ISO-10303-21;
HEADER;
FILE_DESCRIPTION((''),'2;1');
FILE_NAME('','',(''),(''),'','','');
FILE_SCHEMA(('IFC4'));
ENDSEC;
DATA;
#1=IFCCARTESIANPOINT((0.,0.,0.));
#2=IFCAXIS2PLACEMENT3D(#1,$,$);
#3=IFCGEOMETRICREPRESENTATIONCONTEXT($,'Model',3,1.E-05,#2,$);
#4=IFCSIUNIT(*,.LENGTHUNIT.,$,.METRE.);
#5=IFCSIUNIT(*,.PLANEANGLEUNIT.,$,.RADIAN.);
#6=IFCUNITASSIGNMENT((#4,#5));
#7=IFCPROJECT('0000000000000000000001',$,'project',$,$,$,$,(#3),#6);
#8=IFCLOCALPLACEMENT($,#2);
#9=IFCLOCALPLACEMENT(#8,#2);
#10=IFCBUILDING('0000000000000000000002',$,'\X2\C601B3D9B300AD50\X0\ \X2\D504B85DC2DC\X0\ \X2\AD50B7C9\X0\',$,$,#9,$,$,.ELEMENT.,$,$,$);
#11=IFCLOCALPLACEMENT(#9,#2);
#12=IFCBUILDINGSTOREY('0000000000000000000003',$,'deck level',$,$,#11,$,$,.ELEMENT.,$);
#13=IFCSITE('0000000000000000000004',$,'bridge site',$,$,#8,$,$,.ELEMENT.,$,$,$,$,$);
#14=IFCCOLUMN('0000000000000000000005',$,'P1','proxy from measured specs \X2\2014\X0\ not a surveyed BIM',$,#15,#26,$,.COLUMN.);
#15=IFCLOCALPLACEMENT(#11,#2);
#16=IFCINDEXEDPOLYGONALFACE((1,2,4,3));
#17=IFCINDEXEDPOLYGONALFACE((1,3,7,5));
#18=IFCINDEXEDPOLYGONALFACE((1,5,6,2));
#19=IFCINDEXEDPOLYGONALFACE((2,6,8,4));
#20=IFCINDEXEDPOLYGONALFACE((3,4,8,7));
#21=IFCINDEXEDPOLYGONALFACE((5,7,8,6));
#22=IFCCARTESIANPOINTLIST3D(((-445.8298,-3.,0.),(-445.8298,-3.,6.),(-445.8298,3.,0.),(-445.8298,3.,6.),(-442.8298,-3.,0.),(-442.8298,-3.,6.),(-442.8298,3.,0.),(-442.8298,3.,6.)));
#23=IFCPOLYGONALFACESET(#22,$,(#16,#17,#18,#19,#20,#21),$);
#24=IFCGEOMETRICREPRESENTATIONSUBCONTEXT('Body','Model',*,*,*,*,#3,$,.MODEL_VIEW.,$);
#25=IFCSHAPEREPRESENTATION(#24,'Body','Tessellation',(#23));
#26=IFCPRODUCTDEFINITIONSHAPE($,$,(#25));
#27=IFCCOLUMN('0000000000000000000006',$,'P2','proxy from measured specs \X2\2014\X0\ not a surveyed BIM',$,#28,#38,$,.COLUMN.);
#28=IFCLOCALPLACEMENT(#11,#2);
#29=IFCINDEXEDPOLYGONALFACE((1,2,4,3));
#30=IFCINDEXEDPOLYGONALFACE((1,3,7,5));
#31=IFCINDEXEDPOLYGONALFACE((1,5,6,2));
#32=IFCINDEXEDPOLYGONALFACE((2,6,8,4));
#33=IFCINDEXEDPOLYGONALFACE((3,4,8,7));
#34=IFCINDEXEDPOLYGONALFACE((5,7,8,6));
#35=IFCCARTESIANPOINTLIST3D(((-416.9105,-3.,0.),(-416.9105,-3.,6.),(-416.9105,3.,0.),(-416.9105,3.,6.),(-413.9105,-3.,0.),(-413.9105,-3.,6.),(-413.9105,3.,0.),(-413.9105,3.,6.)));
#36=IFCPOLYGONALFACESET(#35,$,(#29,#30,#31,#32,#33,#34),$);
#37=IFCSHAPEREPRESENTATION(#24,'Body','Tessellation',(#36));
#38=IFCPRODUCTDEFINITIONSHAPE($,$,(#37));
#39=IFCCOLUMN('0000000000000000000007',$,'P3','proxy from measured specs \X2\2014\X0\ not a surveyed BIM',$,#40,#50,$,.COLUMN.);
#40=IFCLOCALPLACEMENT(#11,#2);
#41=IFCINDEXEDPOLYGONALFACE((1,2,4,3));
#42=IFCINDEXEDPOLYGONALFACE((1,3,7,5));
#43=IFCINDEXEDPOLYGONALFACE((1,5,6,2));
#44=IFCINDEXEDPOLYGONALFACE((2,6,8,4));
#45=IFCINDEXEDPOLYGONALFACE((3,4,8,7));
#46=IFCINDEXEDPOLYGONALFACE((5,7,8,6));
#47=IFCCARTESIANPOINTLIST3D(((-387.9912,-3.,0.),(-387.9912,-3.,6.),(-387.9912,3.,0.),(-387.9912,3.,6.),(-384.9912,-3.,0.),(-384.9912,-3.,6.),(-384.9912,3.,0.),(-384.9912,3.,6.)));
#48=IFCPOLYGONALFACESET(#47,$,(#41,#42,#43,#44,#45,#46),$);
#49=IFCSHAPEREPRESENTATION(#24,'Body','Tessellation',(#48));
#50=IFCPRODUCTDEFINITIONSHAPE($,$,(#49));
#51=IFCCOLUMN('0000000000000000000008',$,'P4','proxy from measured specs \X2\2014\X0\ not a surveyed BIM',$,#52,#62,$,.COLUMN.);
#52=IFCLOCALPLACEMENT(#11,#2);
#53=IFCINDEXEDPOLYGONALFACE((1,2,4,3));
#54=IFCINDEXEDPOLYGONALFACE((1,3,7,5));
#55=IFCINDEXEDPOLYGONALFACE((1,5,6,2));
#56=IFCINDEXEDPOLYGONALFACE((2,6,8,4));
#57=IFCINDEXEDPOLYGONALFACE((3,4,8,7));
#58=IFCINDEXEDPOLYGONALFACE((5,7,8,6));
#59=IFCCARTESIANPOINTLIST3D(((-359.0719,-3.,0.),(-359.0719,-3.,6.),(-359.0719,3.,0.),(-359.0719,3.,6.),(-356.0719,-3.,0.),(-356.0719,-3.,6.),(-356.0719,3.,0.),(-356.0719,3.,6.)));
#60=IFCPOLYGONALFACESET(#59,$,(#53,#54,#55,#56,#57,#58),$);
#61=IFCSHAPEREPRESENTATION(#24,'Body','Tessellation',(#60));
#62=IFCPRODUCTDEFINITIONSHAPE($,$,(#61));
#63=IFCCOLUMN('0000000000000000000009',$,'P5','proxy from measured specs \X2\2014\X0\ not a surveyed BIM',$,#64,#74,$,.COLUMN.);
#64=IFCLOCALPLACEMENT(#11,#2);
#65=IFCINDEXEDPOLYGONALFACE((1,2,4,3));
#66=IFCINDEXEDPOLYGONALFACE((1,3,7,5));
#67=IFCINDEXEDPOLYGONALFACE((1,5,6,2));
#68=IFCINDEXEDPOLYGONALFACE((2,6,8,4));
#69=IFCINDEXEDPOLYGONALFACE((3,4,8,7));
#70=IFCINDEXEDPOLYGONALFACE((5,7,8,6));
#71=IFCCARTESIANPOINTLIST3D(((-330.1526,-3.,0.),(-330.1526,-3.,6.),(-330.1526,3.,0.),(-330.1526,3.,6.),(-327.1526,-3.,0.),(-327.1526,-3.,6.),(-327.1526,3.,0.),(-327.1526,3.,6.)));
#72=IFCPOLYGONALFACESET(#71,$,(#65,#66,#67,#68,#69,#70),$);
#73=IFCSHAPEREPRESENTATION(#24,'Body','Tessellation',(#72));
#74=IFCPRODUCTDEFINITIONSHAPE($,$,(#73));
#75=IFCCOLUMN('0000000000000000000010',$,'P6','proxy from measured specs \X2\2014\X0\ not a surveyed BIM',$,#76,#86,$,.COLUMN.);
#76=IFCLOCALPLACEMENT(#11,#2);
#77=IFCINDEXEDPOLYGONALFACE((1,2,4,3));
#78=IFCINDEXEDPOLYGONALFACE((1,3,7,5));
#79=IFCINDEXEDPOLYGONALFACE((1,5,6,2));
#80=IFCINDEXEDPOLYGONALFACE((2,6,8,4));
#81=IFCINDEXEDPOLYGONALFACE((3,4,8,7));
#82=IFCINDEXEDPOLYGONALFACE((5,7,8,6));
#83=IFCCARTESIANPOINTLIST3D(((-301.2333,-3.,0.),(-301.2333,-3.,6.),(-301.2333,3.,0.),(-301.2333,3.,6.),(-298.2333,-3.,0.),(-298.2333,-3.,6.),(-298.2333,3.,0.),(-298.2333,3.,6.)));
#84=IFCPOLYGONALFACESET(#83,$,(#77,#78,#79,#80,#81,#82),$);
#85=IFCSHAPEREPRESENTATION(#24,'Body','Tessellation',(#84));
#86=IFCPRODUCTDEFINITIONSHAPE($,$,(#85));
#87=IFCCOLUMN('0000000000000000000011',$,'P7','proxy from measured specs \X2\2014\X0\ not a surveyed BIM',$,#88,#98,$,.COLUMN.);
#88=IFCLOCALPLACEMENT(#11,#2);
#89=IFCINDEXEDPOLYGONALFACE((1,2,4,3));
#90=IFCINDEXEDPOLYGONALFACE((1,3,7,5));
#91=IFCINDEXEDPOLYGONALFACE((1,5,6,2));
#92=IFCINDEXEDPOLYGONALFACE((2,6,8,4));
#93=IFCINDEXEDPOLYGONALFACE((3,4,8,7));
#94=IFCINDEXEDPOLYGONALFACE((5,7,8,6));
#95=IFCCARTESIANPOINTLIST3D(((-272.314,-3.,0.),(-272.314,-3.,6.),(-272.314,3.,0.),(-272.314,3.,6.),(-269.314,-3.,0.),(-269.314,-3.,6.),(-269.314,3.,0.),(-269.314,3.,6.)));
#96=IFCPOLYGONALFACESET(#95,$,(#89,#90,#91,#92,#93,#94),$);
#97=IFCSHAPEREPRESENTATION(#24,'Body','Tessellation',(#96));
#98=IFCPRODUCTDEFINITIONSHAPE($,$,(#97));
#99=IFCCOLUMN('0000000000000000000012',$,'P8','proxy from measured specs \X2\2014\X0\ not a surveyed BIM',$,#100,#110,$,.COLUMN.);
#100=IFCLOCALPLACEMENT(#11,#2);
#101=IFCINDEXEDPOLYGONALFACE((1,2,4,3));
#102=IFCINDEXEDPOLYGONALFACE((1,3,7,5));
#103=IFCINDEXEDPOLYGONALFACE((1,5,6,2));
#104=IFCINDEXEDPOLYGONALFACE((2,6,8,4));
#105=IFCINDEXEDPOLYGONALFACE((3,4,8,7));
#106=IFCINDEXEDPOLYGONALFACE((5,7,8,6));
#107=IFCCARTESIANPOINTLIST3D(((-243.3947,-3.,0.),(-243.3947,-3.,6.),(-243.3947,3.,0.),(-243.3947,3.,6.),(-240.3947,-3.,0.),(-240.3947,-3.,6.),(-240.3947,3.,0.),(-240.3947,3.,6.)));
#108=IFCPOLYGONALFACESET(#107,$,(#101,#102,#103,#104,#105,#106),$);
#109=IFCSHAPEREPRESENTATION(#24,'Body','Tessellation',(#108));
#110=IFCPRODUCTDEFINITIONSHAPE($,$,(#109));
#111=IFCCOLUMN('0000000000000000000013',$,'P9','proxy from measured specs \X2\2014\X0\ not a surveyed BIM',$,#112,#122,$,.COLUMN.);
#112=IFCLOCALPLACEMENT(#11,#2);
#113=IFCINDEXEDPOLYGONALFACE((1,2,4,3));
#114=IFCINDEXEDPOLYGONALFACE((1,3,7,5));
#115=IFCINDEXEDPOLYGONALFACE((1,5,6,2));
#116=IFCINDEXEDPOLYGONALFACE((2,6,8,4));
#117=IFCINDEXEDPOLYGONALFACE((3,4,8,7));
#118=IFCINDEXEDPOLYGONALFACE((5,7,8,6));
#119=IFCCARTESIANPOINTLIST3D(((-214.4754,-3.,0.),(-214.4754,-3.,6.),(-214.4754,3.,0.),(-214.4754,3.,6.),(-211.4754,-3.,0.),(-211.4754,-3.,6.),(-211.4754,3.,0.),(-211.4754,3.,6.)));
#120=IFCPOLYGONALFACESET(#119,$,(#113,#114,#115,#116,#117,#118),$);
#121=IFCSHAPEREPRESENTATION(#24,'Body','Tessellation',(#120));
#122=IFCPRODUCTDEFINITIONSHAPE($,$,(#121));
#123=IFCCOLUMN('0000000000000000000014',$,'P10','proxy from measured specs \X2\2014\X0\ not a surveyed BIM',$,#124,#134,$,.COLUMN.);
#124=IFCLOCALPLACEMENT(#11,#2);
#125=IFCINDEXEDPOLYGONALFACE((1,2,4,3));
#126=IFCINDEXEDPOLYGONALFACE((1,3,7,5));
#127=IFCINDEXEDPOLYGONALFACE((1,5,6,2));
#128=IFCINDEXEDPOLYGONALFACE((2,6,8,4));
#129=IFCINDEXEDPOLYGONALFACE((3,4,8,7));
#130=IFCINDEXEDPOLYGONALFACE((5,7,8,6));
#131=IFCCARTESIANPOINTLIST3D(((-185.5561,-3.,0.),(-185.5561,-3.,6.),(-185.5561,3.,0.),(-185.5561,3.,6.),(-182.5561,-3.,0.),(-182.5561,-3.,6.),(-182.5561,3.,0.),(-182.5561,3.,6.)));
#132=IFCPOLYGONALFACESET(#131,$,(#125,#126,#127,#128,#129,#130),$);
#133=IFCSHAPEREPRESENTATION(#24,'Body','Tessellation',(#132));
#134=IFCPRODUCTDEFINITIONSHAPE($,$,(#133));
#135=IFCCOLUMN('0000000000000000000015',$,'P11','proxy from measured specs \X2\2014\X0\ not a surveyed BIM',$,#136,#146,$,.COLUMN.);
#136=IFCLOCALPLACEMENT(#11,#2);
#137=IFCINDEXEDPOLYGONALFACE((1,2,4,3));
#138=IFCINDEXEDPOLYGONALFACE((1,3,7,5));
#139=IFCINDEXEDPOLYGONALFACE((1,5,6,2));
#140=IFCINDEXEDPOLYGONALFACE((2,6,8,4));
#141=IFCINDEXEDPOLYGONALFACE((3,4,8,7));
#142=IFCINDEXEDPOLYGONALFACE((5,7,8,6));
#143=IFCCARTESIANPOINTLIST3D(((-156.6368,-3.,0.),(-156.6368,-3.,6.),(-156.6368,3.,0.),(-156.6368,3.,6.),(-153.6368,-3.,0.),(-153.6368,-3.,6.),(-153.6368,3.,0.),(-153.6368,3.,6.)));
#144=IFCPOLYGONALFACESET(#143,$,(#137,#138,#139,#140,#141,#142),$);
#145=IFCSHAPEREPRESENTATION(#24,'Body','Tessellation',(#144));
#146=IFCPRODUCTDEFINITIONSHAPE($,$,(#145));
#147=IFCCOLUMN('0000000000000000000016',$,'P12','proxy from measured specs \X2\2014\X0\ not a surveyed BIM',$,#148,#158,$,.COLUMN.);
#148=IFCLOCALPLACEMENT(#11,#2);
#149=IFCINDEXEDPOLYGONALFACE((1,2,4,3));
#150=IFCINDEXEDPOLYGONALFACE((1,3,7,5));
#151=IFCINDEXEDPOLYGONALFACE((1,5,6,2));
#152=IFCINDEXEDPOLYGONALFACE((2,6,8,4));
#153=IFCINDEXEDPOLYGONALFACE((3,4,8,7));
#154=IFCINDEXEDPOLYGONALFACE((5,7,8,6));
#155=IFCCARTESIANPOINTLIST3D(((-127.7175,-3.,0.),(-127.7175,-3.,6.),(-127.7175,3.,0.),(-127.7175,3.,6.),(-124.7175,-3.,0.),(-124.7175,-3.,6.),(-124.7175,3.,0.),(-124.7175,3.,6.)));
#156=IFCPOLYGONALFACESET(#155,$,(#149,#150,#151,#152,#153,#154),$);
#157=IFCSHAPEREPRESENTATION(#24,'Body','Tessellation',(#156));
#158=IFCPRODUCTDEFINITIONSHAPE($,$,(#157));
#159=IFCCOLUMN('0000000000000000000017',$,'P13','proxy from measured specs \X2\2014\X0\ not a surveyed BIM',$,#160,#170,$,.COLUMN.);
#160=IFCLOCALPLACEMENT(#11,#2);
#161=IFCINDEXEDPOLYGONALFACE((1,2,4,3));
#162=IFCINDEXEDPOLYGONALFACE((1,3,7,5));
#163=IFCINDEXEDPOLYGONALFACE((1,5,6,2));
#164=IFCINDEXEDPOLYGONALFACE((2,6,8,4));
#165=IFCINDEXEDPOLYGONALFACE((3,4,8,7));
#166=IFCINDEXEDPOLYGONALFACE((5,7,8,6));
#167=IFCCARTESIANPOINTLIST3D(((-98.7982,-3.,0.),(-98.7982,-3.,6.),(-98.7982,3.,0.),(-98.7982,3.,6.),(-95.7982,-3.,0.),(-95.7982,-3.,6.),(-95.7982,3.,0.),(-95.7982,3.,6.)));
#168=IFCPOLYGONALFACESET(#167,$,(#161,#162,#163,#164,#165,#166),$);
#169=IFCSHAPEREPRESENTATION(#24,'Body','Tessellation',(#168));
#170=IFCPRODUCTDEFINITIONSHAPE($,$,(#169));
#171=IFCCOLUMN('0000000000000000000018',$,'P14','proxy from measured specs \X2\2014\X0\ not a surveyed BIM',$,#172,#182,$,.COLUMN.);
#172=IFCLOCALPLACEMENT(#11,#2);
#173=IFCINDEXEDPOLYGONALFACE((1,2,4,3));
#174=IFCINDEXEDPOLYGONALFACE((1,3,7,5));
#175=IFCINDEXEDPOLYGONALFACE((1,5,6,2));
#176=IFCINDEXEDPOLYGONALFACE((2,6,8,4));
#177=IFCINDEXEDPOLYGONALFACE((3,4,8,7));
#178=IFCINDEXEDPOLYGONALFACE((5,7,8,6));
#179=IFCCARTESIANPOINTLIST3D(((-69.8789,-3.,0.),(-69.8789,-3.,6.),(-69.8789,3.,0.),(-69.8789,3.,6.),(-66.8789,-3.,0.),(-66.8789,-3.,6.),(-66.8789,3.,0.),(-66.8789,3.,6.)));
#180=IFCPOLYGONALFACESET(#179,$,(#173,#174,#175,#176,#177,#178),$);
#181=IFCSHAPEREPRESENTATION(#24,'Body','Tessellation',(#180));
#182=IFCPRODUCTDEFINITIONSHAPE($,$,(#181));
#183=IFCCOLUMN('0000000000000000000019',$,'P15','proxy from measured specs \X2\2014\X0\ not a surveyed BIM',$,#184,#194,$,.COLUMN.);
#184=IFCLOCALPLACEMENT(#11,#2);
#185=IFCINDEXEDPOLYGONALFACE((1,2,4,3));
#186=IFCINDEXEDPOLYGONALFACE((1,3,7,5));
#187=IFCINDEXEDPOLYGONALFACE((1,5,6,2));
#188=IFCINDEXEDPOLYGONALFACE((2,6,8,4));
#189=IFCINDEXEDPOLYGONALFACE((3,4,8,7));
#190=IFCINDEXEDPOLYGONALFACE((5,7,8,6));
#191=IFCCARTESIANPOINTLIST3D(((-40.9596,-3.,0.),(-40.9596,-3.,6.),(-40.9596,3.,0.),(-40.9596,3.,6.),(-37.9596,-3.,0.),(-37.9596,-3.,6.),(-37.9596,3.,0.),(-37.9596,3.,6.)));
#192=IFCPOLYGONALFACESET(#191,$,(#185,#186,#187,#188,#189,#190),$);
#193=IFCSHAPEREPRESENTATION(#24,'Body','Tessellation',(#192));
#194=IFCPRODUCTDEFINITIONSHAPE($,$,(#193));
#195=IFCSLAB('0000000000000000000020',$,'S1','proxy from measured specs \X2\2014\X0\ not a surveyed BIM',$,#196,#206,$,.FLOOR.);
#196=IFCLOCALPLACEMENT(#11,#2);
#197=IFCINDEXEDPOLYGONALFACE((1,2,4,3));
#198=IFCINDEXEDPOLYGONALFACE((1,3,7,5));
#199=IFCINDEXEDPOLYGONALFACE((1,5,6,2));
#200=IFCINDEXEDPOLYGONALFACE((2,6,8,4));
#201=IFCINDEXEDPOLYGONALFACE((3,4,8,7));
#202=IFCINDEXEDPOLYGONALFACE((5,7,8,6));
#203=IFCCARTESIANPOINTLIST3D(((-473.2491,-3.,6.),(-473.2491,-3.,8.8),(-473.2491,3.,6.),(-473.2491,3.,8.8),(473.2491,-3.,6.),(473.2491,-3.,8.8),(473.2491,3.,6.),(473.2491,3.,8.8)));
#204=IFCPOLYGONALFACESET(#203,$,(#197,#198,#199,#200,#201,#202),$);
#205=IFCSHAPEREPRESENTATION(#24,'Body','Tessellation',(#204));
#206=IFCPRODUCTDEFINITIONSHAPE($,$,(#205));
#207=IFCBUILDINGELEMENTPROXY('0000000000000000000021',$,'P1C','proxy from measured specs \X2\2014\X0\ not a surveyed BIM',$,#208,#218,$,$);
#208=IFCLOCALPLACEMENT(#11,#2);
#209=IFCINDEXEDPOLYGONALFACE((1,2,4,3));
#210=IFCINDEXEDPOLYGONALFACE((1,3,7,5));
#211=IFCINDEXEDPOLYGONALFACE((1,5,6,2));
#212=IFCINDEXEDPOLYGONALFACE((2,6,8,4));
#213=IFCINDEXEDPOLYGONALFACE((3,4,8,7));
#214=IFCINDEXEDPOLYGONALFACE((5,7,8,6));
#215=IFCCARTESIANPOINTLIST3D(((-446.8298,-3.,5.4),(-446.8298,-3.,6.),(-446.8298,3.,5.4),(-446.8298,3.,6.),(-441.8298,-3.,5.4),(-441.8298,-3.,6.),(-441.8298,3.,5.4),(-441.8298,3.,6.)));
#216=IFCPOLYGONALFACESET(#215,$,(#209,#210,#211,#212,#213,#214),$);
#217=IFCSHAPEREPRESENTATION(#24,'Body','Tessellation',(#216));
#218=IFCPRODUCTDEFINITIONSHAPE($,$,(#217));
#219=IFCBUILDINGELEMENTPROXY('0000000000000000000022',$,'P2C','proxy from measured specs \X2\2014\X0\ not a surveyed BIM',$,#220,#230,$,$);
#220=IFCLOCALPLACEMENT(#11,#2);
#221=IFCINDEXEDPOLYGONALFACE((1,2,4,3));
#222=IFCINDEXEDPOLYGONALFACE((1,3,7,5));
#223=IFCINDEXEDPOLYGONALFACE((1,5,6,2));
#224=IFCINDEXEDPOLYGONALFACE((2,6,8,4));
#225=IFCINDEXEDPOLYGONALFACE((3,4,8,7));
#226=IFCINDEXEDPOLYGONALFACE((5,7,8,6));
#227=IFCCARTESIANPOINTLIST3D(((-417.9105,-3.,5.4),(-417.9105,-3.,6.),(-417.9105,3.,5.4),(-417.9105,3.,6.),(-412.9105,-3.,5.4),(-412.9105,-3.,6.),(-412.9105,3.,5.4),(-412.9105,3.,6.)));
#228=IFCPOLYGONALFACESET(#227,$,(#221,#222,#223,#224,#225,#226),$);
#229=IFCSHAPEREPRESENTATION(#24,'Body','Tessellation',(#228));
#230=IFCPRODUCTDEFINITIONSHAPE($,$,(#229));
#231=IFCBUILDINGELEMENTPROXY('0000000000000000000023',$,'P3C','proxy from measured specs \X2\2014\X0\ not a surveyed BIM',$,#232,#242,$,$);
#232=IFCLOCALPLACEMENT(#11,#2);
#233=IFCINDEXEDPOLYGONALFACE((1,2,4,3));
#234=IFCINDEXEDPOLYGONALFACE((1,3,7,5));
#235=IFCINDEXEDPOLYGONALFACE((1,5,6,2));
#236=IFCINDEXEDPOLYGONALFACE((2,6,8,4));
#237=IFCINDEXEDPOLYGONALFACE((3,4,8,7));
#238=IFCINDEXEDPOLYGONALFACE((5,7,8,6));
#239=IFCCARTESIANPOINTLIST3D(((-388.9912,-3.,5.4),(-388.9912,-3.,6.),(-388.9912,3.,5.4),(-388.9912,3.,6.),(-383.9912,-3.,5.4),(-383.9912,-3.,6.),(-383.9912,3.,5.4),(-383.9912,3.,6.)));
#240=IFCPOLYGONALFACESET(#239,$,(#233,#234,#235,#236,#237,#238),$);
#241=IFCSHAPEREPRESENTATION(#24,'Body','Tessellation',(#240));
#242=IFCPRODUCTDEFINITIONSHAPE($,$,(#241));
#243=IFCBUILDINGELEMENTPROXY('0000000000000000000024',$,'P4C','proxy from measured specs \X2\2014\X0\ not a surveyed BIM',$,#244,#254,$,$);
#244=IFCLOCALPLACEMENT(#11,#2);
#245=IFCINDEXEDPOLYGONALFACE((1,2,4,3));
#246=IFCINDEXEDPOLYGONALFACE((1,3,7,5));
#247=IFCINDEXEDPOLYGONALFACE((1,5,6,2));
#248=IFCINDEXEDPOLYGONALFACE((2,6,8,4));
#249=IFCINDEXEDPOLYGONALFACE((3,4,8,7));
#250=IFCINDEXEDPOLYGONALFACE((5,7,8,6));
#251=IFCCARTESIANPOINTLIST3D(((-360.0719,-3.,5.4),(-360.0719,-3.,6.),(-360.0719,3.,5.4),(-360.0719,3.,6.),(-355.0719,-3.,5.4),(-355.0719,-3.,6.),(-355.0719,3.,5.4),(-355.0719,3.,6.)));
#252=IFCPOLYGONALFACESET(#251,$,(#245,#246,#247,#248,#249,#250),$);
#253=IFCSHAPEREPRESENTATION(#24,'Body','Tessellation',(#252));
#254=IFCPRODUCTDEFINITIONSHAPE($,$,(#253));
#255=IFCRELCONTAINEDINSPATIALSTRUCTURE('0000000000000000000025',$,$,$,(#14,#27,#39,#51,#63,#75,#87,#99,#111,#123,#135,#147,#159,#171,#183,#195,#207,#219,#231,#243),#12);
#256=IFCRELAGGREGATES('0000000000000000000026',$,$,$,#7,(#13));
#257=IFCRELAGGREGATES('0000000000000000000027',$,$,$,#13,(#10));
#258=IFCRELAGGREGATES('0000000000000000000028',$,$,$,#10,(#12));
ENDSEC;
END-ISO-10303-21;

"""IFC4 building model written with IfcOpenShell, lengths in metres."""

from ifc_helpers import new_model, si_unit, frame, origin, origin_2d, place, context, subcontext, project, spatial, rectangle, extrude, element, save


model = new_model("IFC4")

# Units and contexts
model_context = context("Model", 3, precision=1e-05, world=origin())
body_context = subcontext(model_context, "Body", "Model", "MODEL_VIEW")
ifc_project = project(units=[si_unit("LENGTHUNIT", "METRE"), si_unit("PLANEANGLEUNIT", "RADIAN")], contexts=[model_context])

# Site, building, storey
site_placement = place(None, origin())
site = spatial("IfcSite", under=ifc_project, at=site_placement, Name="bridge site", CompositionType="ELEMENT")
building_placement = place(site_placement, origin())
building = spatial("IfcBuilding", under=site, at=building_placement, Name="영동대교 프록시 교량", CompositionType="ELEMENT")
storey_placement = place(building_placement, origin())
storey = spatial("IfcBuildingStorey", under=building, at=storey_placement, Name="deck level", CompositionType="ELEMENT")

# Columns
for number, where, name in (
    (1, (-444.3298, 0.0, 0.0), "P1"),
    (2, (-415.4105, 0.0, 0.0), "P2"),
    (3, (-386.4912, 0.0, 0.0), "P3"),
    (4, (-357.5719, 0.0, 0.0), "P4"),
    (5, (-328.6526, 0.0, 0.0), "P5"),
    (6, (-299.7333, 0.0, 0.0), "P6"),
    (7, (-270.814, 0.0, 0.0), "P7"),
    (8, (-241.8947, 0.0, 0.0), "P8"),
    (9, (-212.9754, 0.0, 0.0), "P9"),
    (10, (-184.0561, 0.0, 0.0), "P10"),
    (11, (-155.1368, 0.0, 0.0), "P11"),
    (12, (-126.2175, 0.0, 0.0), "P12"),
    (13, (-97.2982, 0.0, 0.0), "P13"),
    (14, (-68.3789, 0.0, 0.0), "P14"),
    (15, (-39.4596, 0.0, 0.0), "P15"),
):
    element("IfcColumn", number, at=place(storey_placement, frame(where)), inside=storey, Name=name, Description="proxy from measured specs — not a surveyed BIM", PredefinedType="COLUMN", context=body_context, shape_type="SweptSolid", body=[
        extrude(rectangle(XDim=3.0, YDim=6.0, at=origin_2d()), origin(), (0.0, 0.0, 1.0), 6.0),
    ])

# Slab
slab_placement = place(storey_placement, frame((0.0, 0.0, 6.0)))
element("IfcSlab", 16, at=slab_placement, inside=storey, Name="S1", Description="proxy from measured specs — not a surveyed BIM", PredefinedType="FLOOR", context=body_context, shape_type="SweptSolid", body=[
    extrude(rectangle(XDim=946.4982, YDim=6.0, at=origin_2d()), origin(), (0.0, 0.0, 1.0), 2.8),
])

# Building element proxies
for number, where, name in (
    (17, (-444.3298, 0.0, 5.4), "P1C"),
    (18, (-415.4105, 0.0, 5.4), "P2C"),
    (19, (-386.4912, 0.0, 5.4), "P3C"),
    (20, (-357.5719, 0.0, 5.4), "P4C"),
):
    element("IfcBuildingElementProxy", number, at=place(storey_placement, frame(where)), inside=storey, Name=name, Description="proxy from measured specs — not a surveyed BIM", context=body_context, shape_type="SweptSolid", body=[
        extrude(rectangle(XDim=5.0, YDim=6.0, at=origin_2d()), origin(), (0.0, 0.0, 1.0), 0.6),
    ])

save(model, "model.ifc")
